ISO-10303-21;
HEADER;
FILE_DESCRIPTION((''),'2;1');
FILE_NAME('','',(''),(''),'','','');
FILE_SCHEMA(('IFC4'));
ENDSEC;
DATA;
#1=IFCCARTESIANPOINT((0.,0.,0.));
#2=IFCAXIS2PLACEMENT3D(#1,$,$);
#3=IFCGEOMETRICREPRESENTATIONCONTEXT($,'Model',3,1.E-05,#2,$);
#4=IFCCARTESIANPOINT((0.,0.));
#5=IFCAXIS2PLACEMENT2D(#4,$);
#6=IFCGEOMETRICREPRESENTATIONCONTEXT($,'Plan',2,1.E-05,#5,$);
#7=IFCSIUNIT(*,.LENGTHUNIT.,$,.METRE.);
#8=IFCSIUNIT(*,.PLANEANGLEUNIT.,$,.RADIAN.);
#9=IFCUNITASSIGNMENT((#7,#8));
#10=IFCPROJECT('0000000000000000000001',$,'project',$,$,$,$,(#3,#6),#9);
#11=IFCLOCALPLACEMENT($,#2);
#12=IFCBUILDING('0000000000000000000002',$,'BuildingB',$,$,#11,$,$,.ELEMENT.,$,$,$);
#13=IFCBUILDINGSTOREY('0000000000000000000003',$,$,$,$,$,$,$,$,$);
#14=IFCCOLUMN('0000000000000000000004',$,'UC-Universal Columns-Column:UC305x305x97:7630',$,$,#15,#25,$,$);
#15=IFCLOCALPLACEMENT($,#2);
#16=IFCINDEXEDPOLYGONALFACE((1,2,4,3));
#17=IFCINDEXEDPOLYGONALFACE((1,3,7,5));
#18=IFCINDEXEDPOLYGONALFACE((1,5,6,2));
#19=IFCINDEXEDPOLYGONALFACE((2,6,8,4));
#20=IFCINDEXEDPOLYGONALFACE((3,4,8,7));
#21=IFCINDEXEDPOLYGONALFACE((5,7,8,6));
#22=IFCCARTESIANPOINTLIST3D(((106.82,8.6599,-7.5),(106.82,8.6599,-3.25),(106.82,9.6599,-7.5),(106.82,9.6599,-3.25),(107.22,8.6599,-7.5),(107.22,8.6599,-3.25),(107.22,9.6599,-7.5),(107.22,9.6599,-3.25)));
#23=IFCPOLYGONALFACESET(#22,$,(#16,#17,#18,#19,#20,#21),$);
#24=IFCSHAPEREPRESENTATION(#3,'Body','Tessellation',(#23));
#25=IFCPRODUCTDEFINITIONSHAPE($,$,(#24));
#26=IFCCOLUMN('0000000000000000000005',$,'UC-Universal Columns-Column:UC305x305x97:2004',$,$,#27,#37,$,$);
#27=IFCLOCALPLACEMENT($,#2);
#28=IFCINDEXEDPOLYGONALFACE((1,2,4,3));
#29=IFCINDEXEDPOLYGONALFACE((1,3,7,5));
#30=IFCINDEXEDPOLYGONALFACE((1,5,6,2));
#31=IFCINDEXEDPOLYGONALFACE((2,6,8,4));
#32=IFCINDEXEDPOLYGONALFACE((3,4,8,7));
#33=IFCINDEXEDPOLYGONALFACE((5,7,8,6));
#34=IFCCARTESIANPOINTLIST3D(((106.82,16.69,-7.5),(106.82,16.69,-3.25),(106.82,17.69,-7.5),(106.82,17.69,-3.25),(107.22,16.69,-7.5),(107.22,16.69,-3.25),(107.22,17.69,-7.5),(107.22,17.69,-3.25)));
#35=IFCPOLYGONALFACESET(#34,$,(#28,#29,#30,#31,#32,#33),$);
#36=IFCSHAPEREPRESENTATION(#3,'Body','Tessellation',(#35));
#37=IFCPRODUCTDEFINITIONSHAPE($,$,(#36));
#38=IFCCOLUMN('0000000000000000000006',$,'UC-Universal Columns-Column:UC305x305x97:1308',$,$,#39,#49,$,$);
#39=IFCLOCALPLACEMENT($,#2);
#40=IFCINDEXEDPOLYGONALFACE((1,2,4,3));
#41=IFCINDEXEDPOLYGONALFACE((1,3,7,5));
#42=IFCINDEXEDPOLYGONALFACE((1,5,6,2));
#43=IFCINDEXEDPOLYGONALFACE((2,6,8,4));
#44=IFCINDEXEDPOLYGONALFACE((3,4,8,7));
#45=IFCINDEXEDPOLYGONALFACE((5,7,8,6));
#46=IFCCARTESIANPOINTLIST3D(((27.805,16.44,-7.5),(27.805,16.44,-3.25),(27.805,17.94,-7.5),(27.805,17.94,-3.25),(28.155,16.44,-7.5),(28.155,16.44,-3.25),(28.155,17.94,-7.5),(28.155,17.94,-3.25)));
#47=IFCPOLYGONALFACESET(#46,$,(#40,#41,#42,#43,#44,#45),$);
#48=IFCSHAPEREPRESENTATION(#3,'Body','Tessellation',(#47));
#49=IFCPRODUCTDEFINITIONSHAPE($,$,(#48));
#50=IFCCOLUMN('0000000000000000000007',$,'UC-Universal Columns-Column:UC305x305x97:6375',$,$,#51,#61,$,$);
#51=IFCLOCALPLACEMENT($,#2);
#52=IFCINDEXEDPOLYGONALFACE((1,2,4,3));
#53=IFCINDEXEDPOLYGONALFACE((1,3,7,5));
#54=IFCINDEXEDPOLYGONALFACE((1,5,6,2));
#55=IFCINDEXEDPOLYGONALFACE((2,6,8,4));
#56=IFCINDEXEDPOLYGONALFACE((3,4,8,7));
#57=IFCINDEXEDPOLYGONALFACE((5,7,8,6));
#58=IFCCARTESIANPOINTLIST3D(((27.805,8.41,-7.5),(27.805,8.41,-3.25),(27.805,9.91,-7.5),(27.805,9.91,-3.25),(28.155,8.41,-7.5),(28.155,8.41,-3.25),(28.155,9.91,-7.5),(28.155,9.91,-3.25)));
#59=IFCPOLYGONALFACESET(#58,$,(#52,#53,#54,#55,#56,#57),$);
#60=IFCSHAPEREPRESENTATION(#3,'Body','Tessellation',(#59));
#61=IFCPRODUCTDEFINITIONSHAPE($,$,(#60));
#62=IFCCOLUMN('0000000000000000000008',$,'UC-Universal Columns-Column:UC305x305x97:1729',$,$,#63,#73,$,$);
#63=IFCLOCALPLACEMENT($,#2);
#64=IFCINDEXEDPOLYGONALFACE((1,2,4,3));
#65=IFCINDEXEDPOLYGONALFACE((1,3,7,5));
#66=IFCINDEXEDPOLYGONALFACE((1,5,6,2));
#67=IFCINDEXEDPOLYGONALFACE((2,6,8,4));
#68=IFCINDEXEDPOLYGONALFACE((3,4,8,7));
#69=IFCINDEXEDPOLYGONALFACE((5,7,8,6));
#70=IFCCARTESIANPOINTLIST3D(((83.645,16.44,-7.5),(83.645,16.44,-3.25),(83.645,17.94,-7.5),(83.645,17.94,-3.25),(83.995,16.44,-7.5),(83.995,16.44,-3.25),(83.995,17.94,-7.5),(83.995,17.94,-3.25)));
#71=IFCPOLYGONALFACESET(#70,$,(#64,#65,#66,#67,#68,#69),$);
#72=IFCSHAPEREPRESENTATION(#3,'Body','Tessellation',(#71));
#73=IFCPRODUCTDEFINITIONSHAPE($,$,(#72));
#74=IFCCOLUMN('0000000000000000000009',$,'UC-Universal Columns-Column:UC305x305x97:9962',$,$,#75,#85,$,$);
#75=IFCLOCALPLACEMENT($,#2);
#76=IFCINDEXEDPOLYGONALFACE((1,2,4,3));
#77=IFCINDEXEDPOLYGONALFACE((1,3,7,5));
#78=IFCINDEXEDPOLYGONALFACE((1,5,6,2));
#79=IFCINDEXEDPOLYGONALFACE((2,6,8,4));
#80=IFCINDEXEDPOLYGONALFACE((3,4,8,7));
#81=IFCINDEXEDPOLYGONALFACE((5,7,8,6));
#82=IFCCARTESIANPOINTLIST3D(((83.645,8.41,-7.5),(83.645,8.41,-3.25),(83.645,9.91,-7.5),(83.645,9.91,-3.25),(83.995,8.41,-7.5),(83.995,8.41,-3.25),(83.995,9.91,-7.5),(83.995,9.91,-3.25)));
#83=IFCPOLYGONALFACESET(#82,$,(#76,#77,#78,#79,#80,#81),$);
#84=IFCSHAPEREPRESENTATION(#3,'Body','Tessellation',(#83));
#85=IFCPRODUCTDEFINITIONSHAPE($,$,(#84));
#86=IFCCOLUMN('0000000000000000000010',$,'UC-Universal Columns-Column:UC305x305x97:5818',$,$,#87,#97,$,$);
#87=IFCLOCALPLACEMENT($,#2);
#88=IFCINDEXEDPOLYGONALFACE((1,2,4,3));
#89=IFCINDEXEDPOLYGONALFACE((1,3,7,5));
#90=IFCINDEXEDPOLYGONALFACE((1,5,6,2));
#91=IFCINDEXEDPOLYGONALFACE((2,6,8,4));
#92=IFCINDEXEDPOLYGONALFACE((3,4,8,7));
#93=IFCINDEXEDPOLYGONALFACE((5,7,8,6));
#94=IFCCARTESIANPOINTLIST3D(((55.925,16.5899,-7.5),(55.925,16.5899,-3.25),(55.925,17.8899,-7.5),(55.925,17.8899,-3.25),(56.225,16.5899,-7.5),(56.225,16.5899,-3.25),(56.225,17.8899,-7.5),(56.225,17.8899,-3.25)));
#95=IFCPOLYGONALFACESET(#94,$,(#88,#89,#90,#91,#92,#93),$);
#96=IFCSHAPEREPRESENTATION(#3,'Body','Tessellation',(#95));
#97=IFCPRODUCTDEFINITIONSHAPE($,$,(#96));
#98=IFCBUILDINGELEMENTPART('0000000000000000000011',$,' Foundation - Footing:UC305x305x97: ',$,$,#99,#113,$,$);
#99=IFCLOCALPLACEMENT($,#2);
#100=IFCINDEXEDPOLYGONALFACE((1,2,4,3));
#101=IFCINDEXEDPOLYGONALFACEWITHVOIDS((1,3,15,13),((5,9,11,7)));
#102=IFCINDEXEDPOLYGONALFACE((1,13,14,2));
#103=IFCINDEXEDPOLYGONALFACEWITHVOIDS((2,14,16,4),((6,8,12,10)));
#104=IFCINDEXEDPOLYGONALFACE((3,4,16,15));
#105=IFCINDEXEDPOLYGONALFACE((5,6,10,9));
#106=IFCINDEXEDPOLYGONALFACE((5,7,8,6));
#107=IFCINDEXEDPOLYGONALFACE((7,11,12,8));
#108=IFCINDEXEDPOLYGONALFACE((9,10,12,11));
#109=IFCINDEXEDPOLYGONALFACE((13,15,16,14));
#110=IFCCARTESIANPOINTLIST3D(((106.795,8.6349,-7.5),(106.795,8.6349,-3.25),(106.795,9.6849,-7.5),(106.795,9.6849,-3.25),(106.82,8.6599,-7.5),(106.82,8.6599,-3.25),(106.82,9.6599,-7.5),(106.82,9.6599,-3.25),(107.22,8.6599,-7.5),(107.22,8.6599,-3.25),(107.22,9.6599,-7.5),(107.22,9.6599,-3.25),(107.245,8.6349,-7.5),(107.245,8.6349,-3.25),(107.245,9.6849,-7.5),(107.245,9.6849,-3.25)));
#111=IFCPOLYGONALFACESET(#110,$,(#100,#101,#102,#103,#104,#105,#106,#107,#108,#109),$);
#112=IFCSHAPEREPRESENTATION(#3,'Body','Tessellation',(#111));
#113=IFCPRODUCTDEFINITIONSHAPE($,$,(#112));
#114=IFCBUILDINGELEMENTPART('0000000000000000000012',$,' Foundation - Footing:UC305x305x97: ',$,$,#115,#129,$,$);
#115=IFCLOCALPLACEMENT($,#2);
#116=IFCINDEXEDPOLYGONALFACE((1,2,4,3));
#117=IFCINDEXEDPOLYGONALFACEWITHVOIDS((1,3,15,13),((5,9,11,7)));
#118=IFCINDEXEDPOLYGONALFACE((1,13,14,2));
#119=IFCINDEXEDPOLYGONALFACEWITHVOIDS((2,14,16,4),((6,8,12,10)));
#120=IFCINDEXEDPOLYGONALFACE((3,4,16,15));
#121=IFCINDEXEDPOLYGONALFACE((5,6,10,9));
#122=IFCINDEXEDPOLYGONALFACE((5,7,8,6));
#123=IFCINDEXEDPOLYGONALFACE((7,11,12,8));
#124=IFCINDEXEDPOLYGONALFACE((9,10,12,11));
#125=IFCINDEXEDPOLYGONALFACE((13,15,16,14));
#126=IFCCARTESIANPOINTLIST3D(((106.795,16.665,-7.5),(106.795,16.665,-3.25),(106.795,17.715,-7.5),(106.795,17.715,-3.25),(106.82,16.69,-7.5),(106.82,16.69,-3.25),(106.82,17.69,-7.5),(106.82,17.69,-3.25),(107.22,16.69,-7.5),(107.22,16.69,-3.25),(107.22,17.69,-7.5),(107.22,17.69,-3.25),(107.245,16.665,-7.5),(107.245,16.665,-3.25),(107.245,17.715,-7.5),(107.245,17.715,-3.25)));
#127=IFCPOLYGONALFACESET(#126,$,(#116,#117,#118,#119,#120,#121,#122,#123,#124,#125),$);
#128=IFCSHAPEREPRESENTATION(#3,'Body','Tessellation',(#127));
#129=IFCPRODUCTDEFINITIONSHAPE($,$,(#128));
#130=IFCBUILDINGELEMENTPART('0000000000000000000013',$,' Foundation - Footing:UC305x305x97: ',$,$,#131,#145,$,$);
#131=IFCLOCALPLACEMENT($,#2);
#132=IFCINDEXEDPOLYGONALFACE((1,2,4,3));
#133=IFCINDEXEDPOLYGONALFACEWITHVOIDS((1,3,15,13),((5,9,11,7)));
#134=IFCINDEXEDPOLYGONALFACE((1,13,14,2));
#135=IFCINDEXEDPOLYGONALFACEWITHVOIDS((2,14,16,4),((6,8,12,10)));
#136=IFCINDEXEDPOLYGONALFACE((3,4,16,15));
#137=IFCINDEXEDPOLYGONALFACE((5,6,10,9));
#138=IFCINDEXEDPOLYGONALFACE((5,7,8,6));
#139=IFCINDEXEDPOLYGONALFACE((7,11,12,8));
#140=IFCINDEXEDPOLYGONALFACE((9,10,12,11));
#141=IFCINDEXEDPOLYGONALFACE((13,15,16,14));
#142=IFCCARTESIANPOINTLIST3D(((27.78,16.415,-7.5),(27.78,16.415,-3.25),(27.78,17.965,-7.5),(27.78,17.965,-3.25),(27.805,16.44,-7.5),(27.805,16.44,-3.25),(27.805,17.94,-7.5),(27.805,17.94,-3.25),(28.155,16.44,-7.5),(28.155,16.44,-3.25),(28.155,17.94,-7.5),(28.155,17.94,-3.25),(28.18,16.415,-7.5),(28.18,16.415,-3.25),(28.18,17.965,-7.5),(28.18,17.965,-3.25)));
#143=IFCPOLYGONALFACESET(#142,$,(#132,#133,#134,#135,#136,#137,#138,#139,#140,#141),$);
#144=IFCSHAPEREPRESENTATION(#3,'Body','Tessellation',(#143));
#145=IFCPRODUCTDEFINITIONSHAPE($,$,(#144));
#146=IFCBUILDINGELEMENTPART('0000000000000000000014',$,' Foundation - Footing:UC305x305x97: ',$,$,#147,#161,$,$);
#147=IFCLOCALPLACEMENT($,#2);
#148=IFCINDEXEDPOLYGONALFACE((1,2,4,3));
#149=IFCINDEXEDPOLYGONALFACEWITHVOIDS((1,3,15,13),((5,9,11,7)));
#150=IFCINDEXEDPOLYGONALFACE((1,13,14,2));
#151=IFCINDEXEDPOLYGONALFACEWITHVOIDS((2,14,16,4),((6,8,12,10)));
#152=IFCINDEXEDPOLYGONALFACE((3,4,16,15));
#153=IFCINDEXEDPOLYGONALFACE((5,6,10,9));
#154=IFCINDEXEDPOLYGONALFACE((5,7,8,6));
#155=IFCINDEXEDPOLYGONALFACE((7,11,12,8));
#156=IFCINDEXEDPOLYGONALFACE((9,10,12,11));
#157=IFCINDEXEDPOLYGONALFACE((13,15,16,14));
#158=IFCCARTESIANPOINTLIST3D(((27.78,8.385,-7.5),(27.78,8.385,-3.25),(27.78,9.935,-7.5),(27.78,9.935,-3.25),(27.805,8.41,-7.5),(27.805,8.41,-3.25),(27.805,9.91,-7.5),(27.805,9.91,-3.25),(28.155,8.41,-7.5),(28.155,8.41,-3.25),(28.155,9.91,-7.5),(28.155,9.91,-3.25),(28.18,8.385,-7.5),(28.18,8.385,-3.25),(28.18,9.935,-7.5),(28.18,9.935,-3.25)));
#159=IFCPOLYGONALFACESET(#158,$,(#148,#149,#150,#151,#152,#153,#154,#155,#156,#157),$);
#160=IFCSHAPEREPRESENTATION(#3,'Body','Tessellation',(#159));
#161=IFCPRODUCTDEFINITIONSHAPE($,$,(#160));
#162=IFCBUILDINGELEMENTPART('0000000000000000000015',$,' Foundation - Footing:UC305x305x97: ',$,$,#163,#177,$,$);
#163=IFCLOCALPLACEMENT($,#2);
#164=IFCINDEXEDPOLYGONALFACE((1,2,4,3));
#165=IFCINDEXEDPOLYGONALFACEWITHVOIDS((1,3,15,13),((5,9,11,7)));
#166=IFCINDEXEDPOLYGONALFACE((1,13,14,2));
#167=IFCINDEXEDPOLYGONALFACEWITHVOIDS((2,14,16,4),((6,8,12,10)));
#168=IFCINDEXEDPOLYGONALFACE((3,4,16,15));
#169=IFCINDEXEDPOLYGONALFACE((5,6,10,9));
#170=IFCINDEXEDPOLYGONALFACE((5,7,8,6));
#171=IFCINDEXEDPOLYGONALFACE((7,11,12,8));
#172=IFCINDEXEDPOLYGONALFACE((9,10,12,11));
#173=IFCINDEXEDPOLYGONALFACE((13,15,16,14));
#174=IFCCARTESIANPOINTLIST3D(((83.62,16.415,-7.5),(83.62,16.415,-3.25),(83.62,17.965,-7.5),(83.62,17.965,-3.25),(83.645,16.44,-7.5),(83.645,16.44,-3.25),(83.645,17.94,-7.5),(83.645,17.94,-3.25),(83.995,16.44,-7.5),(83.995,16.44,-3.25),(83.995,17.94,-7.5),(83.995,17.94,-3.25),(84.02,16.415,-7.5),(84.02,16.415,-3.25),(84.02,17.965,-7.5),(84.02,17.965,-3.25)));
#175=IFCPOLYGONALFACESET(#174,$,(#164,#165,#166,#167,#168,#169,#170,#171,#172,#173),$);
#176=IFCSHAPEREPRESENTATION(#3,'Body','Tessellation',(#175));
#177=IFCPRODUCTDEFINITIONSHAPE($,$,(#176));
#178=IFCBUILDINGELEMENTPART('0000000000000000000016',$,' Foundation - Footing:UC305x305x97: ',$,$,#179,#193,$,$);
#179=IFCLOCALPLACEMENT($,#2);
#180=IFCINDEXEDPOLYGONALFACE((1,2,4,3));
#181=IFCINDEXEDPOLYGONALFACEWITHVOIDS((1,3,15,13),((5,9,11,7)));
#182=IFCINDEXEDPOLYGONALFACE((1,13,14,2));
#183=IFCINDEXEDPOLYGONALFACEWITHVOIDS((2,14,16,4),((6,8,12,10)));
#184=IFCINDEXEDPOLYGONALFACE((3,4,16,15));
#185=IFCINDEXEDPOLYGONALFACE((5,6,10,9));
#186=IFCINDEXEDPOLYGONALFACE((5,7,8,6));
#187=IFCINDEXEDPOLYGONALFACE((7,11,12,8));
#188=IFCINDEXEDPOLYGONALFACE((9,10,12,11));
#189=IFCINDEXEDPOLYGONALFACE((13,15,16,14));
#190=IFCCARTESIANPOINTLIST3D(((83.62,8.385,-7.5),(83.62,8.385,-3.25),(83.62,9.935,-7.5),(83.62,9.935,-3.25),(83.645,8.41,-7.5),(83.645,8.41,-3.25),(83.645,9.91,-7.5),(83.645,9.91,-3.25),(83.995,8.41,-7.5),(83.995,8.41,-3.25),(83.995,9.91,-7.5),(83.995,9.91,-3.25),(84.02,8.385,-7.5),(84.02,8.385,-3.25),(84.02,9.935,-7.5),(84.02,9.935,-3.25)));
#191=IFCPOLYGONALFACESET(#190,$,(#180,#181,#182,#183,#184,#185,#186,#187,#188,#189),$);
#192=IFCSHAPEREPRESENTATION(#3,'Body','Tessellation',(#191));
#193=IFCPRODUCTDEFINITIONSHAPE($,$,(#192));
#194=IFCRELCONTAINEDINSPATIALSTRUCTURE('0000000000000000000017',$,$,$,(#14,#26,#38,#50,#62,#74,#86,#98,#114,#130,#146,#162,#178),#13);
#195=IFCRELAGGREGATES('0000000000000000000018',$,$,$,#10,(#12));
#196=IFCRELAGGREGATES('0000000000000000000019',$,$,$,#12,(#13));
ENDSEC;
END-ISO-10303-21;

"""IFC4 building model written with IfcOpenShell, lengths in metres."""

from ifc_helpers import new_model, si_unit, origin, origin_2d, place, context, project, spatial, polyline, outline, extrude, element, save


model = new_model("IFC4")

# Units and contexts
model_context = context("Model", 3, precision=1e-05, world=origin())
plan_context = context("Plan", 2, precision=1e-05, world=origin_2d())
ifc_project = project(units=[si_unit("LENGTHUNIT", "METRE"), si_unit("PLANEANGLEUNIT", "RADIAN")], contexts=[model_context, plan_context])

# Building, storey
building_placement = place(None, origin())
building = spatial("IfcBuilding", under=ifc_project, at=building_placement, Name="BuildingB", CompositionType="ELEMENT")
storey = spatial("IfcBuildingStorey", under=building)

# Columns
element("IfcColumn", 1, inside=storey, Name="UC-Universal Columns-Column:UC305x305x97:7630", context=model_context, shape_type="SweptSolid", body=[
    extrude(outline(polyline([(107.22, 8.6599, -7.5), (106.82, 8.6599, -7.5), (106.82, 9.6599, -7.5), (107.22, 9.6599, -7.5), (107.22, 8.6599, -7.5)])), None, (0.0, 0.0, 1.0), 4.25),
])
element("IfcColumn", 2, inside=storey, Name="UC-Universal Columns-Column:UC305x305x97:2004", context=model_context, shape_type="SweptSolid", body=[
    extrude(outline(polyline([(107.22, 17.69, -7.5), (106.82, 17.69, -7.5), (106.82, 16.69, -7.5), (107.22, 16.69, -7.5), (107.22, 17.69, -7.5)])), None, (0.0, 0.0, 1.0), 4.25),
])
element("IfcColumn", 3, inside=storey, Name="UC-Universal Columns-Column:UC305x305x97:1308", context=model_context, shape_type="SweptSolid", body=[
    extrude(outline(polyline([(28.155, 17.94, -7.5), (27.805, 17.94, -7.5), (27.805, 16.44, -7.5), (28.155, 16.44, -7.5), (28.155, 17.94, -7.5)])), None, (0.0, 0.0, 1.0), 4.25),
])
element("IfcColumn", 4, inside=storey, Name="UC-Universal Columns-Column:UC305x305x97:6375", context=model_context, shape_type="SweptSolid", body=[
    extrude(outline(polyline([(28.155, 9.91, -7.5), (27.805, 9.91, -7.5), (27.805, 8.41, -7.5), (28.155, 8.41, -7.5), (28.155, 9.91, -7.5)])), None, (0.0, 0.0, 1.0), 4.25),
])
element("IfcColumn", 5, inside=storey, Name="UC-Universal Columns-Column:UC305x305x97:1729", context=model_context, shape_type="SweptSolid", body=[
    extrude(outline(polyline([(83.995, 17.94, -7.5), (83.645, 17.94, -7.5), (83.645, 16.44, -7.5), (83.995, 16.44, -7.5), (83.995, 17.94, -7.5)])), None, (0.0, 0.0, 1.0), 4.25),
])
element("IfcColumn", 6, inside=storey, Name="UC-Universal Columns-Column:UC305x305x97:9962", context=model_context, shape_type="SweptSolid", body=[
    extrude(outline(polyline([(83.995, 9.91, -7.5), (83.645, 9.91, -7.5), (83.645, 8.41, -7.5), (83.995, 8.41, -7.5), (83.995, 9.91, -7.5)])), None, (0.0, 0.0, 1.0), 4.25),
])
element("IfcColumn", 7, inside=storey, Name="UC-Universal Columns-Column:UC305x305x97:5818", context=model_context, shape_type="SweptSolid", body=[
    extrude(outline(polyline([(55.925, 17.8899, -7.5), (55.925, 16.5899, -7.5), (56.225, 16.5899, -7.5), (56.225, 17.8899, -7.5), (55.925, 17.8899, -7.5)])), None, (0.0, 0.0, 1.0), 4.25),
])

# Building element parts, openings
building_element_part_1 = element("IfcBuildingElementPart", 8, inside=storey, Name=" Foundation - Footing:UC305x305x97: ", context=model_context, shape_type="SweptSolid", body=[
    extrude(outline(polyline([(107.245, 8.6349, -7.5), (106.795, 8.6349, -7.5), (106.795, 9.6849, -7.5), (107.245, 9.6849, -7.5), (107.245, 8.6349, -7.5)])), None, (0.0, 0.0, 1.0), 4.25),
])
element("IfcOpeningElement", 9, inside=storey, cuts=building_element_part_1, context=model_context, shape_type="SweptSolid", body=[
    extrude(outline(polyline([(107.22, 8.6599, -7.5), (106.82, 8.6599, -7.5), (106.82, 9.6599, -7.5), (107.22, 9.6599, -7.5), (107.22, 8.6599, -7.5)])), None, (0.0, 0.0, 1.0), 4.25),
])
building_element_part_2 = element("IfcBuildingElementPart", 10, inside=storey, Name=" Foundation - Footing:UC305x305x97: ", context=model_context, shape_type="SweptSolid", body=[
    extrude(outline(polyline([(107.245, 17.715, -7.5), (106.795, 17.715, -7.5), (106.795, 16.665, -7.5), (107.245, 16.665, -7.5), (107.245, 17.715, -7.5)])), None, (0.0, 0.0, 1.0), 4.25),
])
element("IfcOpeningElement", 11, inside=storey, cuts=building_element_part_2, context=model_context, shape_type="SweptSolid", body=[
    extrude(outline(polyline([(107.22, 17.69, -7.5), (106.82, 17.69, -7.5), (106.82, 16.69, -7.5), (107.22, 16.69, -7.5), (107.22, 17.69, -7.5)])), None, (0.0, 0.0, 1.0), 4.25),
])
building_element_part_3 = element("IfcBuildingElementPart", 12, inside=storey, Name=" Foundation - Footing:UC305x305x97: ", context=model_context, shape_type="SweptSolid", body=[
    extrude(outline(polyline([(28.18, 17.965, -7.5), (27.78, 17.965, -7.5), (27.78, 16.415, -7.5), (28.18, 16.415, -7.5), (28.18, 17.965, -7.5)])), None, (0.0, 0.0, 1.0), 4.25),
])
element("IfcOpeningElement", 13, inside=storey, cuts=building_element_part_3, context=model_context, shape_type="SweptSolid", body=[
    extrude(outline(polyline([(28.155, 17.94, -7.5), (27.805, 17.94, -7.5), (27.805, 16.44, -7.5), (28.155, 16.44, -7.5), (28.155, 17.94, -7.5)])), None, (0.0, 0.0, 1.0), 4.25),
])
building_element_part_4 = element("IfcBuildingElementPart", 14, inside=storey, Name=" Foundation - Footing:UC305x305x97: ", context=model_context, shape_type="SweptSolid", body=[
    extrude(outline(polyline([(28.18, 9.935, -7.5), (27.78, 9.935, -7.5), (27.78, 8.385, -7.5), (28.18, 8.385, -7.5), (28.18, 9.935, -7.5)])), None, (0.0, 0.0, 1.0), 4.25),
])
element("IfcOpeningElement", 15, inside=storey, cuts=building_element_part_4, context=model_context, shape_type="SweptSolid", body=[
    extrude(outline(polyline([(28.155, 9.91, -7.5), (27.805, 9.91, -7.5), (27.805, 8.41, -7.5), (28.155, 8.41, -7.5), (28.155, 9.91, -7.5)])), None, (0.0, 0.0, 1.0), 4.25),
])
building_element_part_5 = element("IfcBuildingElementPart", 16, inside=storey, Name=" Foundation - Footing:UC305x305x97: ", context=model_context, shape_type="SweptSolid", body=[
    extrude(outline(polyline([(84.02, 17.965, -7.5), (83.62, 17.965, -7.5), (83.62, 16.415, -7.5), (84.02, 16.415, -7.5), (84.02, 17.965, -7.5)])), None, (0.0, 0.0, 1.0), 4.25),
])
element("IfcOpeningElement", 17, inside=storey, cuts=building_element_part_5, context=model_context, shape_type="SweptSolid", body=[
    extrude(outline(polyline([(83.995, 17.94, -7.5), (83.645, 17.94, -7.5), (83.645, 16.44, -7.5), (83.995, 16.44, -7.5), (83.995, 17.94, -7.5)])), None, (0.0, 0.0, 1.0), 4.25),
])
building_element_part_6 = element("IfcBuildingElementPart", 18, inside=storey, Name=" Foundation - Footing:UC305x305x97: ", context=model_context, shape_type="SweptSolid", body=[
    extrude(outline(polyline([(84.02, 9.935, -7.5), (83.62, 9.935, -7.5), (83.62, 8.385, -7.5), (84.02, 8.385, -7.5), (84.02, 9.935, -7.5)])), None, (0.0, 0.0, 1.0), 4.25),
])
element("IfcOpeningElement", 19, inside=storey, cuts=building_element_part_6, context=model_context, shape_type="SweptSolid", body=[
    extrude(outline(polyline([(83.995, 9.91, -7.5), (83.645, 9.91, -7.5), (83.645, 8.41, -7.5), (83.995, 8.41, -7.5), (83.995, 9.91, -7.5)])), None, (0.0, 0.0, 1.0), 4.25),
])

save(model, "model.ifc")
